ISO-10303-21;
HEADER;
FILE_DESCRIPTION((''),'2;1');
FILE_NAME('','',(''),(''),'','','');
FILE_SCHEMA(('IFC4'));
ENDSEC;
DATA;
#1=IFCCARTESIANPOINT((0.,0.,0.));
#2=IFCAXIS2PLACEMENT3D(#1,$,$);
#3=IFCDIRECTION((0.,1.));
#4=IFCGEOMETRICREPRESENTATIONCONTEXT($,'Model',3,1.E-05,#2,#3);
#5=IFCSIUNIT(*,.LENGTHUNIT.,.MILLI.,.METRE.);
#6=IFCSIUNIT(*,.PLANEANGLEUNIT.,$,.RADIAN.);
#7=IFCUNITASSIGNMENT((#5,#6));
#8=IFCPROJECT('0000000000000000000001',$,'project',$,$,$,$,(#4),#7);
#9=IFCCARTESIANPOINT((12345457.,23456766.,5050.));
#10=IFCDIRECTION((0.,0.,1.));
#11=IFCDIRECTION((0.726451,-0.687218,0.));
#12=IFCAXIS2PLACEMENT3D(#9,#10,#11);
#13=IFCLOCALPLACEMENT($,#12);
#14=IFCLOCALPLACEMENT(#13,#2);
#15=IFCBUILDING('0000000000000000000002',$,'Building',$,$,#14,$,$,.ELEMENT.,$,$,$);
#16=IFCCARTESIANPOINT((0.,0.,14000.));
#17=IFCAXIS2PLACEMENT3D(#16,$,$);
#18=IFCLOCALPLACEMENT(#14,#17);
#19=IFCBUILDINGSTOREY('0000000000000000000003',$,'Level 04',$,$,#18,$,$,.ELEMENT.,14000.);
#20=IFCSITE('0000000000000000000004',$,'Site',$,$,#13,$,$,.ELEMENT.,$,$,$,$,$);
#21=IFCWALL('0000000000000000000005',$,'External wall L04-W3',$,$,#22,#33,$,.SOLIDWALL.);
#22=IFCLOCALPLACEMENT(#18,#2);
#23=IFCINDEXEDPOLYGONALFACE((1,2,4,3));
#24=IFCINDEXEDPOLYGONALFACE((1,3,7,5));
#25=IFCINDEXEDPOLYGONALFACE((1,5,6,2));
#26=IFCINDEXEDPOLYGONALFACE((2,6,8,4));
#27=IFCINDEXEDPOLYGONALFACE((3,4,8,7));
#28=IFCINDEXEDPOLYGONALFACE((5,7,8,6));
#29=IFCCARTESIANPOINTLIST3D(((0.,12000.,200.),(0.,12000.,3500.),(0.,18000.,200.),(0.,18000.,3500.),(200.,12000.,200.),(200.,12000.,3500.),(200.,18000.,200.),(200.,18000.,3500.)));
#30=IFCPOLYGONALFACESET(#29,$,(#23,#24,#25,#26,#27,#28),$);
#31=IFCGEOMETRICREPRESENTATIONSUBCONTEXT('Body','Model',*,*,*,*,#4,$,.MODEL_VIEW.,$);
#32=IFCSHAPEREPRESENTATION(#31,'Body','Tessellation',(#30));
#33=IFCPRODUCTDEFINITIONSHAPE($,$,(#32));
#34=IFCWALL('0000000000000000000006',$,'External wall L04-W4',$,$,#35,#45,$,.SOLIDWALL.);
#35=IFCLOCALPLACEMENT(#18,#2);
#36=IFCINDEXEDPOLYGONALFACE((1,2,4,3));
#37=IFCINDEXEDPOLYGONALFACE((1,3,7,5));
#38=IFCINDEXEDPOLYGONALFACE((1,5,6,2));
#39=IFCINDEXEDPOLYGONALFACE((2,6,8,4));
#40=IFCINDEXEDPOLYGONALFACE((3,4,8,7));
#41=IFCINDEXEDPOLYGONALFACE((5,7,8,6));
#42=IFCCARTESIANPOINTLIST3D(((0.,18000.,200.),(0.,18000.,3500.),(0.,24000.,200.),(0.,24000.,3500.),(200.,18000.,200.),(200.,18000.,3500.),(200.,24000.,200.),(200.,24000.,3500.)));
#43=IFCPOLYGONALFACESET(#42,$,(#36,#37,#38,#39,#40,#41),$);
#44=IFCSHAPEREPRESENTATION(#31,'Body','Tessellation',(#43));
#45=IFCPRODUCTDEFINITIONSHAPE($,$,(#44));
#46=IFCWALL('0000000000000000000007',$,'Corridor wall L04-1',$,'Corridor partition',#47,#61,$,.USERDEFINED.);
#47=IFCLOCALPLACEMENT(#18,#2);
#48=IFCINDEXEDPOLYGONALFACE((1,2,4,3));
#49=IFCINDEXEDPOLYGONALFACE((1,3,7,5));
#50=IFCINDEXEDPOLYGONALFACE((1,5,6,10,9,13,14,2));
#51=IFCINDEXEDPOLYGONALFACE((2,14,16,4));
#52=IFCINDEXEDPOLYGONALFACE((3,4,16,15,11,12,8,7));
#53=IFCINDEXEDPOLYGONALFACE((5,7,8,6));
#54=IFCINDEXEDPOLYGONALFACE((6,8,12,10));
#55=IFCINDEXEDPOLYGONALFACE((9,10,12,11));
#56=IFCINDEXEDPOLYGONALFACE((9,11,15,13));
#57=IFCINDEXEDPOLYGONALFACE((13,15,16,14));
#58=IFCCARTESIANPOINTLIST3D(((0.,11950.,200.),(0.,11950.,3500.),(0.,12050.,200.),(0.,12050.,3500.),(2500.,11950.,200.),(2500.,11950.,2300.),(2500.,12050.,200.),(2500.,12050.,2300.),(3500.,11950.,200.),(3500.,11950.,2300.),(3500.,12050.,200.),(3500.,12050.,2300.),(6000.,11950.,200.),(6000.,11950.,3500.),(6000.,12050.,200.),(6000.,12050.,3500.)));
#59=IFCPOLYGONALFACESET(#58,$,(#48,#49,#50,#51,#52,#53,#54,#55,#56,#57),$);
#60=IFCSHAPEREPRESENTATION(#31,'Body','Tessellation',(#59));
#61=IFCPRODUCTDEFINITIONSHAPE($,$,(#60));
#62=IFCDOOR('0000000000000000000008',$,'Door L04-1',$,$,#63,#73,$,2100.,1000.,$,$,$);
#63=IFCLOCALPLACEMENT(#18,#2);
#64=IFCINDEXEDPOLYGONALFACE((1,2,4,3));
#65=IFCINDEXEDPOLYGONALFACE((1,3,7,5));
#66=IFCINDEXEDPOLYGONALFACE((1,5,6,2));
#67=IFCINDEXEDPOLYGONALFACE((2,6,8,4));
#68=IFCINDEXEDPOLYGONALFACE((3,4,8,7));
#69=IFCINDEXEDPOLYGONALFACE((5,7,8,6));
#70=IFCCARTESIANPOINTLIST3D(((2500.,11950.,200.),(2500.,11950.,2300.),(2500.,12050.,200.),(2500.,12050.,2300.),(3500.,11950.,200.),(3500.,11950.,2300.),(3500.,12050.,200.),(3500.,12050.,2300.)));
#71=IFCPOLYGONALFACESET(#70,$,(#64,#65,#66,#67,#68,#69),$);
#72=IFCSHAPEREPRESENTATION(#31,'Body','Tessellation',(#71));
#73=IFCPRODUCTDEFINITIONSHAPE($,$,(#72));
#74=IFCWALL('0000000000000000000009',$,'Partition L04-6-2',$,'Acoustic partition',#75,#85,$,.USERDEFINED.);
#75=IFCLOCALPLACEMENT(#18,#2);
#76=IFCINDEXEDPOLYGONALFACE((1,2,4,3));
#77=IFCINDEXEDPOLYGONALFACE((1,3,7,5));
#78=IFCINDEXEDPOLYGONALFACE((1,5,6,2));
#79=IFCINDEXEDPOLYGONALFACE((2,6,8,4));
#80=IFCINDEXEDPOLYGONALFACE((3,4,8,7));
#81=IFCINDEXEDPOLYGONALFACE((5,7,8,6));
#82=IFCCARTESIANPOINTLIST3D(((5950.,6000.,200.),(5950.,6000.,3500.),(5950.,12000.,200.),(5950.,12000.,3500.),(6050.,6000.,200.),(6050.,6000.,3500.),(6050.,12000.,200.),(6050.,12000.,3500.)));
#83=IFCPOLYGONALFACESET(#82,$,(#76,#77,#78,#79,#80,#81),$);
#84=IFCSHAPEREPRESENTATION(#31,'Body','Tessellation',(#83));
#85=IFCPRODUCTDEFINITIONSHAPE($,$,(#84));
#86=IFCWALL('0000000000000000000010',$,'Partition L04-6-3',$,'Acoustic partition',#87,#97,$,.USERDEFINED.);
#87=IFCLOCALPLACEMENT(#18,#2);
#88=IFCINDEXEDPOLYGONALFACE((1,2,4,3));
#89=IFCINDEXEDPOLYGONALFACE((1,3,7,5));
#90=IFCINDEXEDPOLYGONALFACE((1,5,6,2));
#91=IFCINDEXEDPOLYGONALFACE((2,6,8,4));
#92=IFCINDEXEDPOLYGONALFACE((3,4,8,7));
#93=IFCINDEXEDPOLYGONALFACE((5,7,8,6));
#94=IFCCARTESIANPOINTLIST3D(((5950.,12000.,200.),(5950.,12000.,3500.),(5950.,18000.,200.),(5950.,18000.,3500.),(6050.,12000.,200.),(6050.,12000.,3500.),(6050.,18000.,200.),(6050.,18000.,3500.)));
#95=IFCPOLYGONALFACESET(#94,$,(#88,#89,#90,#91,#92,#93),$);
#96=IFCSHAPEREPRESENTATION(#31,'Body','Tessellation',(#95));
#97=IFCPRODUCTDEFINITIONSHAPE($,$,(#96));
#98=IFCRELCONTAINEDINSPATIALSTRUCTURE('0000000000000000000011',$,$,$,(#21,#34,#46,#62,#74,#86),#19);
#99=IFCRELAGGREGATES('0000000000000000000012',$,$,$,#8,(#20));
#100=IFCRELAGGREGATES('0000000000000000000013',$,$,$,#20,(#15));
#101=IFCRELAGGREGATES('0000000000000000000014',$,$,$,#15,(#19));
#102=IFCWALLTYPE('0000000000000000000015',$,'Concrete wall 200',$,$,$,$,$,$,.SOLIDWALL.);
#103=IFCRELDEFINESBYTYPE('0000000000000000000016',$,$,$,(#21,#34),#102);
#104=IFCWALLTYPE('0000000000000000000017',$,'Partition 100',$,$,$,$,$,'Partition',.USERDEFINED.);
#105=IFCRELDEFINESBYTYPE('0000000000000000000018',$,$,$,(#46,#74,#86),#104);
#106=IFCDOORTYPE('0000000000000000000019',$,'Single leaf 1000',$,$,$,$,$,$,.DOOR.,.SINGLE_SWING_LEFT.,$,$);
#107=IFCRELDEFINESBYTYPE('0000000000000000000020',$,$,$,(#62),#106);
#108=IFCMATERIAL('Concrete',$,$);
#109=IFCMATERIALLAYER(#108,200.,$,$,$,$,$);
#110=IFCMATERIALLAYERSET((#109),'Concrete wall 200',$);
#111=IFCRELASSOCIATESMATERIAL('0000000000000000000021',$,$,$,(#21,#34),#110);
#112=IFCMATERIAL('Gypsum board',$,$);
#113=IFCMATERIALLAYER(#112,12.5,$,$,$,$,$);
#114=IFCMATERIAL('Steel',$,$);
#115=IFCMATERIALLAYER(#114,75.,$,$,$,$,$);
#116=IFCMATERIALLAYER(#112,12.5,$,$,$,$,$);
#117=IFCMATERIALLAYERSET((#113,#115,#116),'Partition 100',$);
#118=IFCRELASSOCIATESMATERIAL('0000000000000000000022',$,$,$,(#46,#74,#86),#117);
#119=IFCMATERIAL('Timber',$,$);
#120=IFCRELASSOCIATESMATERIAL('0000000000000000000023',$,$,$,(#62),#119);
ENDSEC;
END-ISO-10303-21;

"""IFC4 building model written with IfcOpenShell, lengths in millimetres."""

from ifc_helpers import new_model, si_unit, direction, frame, origin, place, context, subcontext, project, spatial, rectangle, extrude, source, transform, mapped, material, layer, layer_set, layer_usage, type_object, type_shapes, element, fill, save


model = new_model("IFC4")

# Units and contexts
model_context = context("Model", 3, precision=1e-05, world=origin(), true_north=direction((0.0, 1.0)))
body_context = subcontext(model_context, "Body", "Model", "MODEL_VIEW")
ifc_project = project(units=[si_unit("LENGTHUNIT", "METRE", prefix="MILLI"), si_unit("PLANEANGLEUNIT", "RADIAN")], contexts=[model_context])

# Site, building, storey
site_placement = place(None, frame((12345457.0, 23456766.0, 5050.0), z_axis=(0.0, 0.0, 1.0), x_axis=(0.726451, -0.687218, 0.0)))
site = spatial("IfcSite", under=ifc_project, at=site_placement, Name="Site", CompositionType="ELEMENT")
building_placement = place(site_placement, origin())
building = spatial("IfcBuilding", under=site, at=building_placement, Name="Building", CompositionType="ELEMENT")
storey_placement = place(building_placement, frame((0.0, 0.0, 14000.0)))
storey = spatial("IfcBuildingStorey", under=building, at=storey_placement, Name="Level 04", CompositionType="ELEMENT", Elevation=14000.0)

# Shared definitions
ifc_material_1 = material(Name="Steel")

# Shared definitions
ifc_material_2 = material(Name="Concrete")

# Walls
ifc_layer_1 = layer(ifc_material_2, 200.0)
ifc_layer_set_1 = layer_set([ifc_layer_1], Name="Concrete wall 200")
ifc_layer_usage_1 = layer_usage(ifc_layer_set_1, "AXIS2", "POSITIVE", 0.0)
wall_type_1 = type_object("IfcWallType", Name="Concrete wall 200", PredefinedType="SOLIDWALL")
for number, where, name in (
    (1, (0.0, 12000.0, 200.0), "External wall L04-W3"),
    (2, (0.0, 18000.0, 200.0), "External wall L04-W4"),
):
    element("IfcWall", number, at=place(storey_placement, frame(where)), inside=storey, type_object=wall_type_1, material=ifc_layer_usage_1, Name=name, PredefinedType="SOLIDWALL", context=body_context, shape_type="SweptSolid", body=[
        extrude(rectangle(XDim=200.0, YDim=6000.0), frame((100.0, 3000.0, 0.0)), (0.0, 0.0, 1.0), 3300.0),
    ])

# Wall, opening, door
ifc_material_3 = material(Name="Gypsum board")
ifc_layer_2 = layer(ifc_material_3, 12.5)
ifc_layer_3 = layer(ifc_material_1, 75.0)
ifc_layer_4 = layer(ifc_material_3, 12.5)
ifc_layer_set_2 = layer_set([ifc_layer_2, ifc_layer_3, ifc_layer_4], Name="Partition 100")
ifc_layer_usage_2 = layer_usage(ifc_layer_set_2, "AXIS2", "POSITIVE", 0.0)
wall_type_2 = type_object("IfcWallType", Name="Partition 100", ElementType="Partition", PredefinedType="USERDEFINED")
wall_placement = place(storey_placement, frame((0.0, 11950.0, 200.0)))
wall = element("IfcWall", 3, at=wall_placement, inside=storey, type_object=wall_type_2, material=ifc_layer_usage_2, Name="Corridor wall L04-1", ObjectType="Corridor partition", PredefinedType="USERDEFINED", context=body_context, shape_type="SweptSolid", body=[
    extrude(rectangle(XDim=6000.0, YDim=100.0), frame((3000.0, 50.0, 0.0)), (0.0, 0.0, 1.0), 3300.0),
])
opening_placement = place(wall_placement, frame((2500.0, -50.0, 0.0)))
opening = element("IfcOpeningElement", 4, at=opening_placement, cuts=wall, PredefinedType="OPENING", context=body_context, shape_type="SweptSolid", body=[
    extrude(rectangle(XDim=1000.0, YDim=200.0), frame((500.0, 100.0, 0.0)), (0.0, 0.0, 1.0), 2100.0),
])
ifc_material_4 = material(Name="Timber")
door_type = type_object("IfcDoorType", Name="Single leaf 1000", OperationType="SINGLE_SWING_LEFT", PredefinedType="DOOR")
shared_shape = source(origin(), body_context, "Body", "SweptSolid", [
    extrude(rectangle(XDim=1000.0, YDim=100.0), frame((500.0, 50.0, 0.0)), (0.0, 0.0, 1.0), 2100.0),
])
type_shapes(door_type, [shared_shape])
door_placement = place(storey_placement, frame((2500.0, 11950.0, 200.0)))
door = element("IfcDoor", 5, at=door_placement, inside=storey, type_object=door_type, material=ifc_material_4, Name="Door L04-1", OverallHeight=2100.0, OverallWidth=1000.0, context=body_context, shape_type="MappedRepresentation", body=[
    mapped(shared_shape, transform((0.0, 0.0, 0.0))),
])
fill(opening, door)

# Walls
for number, where, name in (
    (6, (5950.0, 6000.0, 200.0), "Partition L04-6-2"),
    (7, (5950.0, 12000.0, 200.0), "Partition L04-6-3"),
):
    element("IfcWall", number, at=place(storey_placement, frame(where)), inside=storey, type_object=wall_type_2, material=ifc_layer_usage_2, Name=name, ObjectType="Acoustic partition", PredefinedType="USERDEFINED", context=body_context, shape_type="SweptSolid", body=[
        extrude(rectangle(XDim=100.0, YDim=6000.0), frame((50.0, 3000.0, 0.0)), (0.0, 0.0, 1.0), 3300.0),
    ])

save(model, "model.ifc")
